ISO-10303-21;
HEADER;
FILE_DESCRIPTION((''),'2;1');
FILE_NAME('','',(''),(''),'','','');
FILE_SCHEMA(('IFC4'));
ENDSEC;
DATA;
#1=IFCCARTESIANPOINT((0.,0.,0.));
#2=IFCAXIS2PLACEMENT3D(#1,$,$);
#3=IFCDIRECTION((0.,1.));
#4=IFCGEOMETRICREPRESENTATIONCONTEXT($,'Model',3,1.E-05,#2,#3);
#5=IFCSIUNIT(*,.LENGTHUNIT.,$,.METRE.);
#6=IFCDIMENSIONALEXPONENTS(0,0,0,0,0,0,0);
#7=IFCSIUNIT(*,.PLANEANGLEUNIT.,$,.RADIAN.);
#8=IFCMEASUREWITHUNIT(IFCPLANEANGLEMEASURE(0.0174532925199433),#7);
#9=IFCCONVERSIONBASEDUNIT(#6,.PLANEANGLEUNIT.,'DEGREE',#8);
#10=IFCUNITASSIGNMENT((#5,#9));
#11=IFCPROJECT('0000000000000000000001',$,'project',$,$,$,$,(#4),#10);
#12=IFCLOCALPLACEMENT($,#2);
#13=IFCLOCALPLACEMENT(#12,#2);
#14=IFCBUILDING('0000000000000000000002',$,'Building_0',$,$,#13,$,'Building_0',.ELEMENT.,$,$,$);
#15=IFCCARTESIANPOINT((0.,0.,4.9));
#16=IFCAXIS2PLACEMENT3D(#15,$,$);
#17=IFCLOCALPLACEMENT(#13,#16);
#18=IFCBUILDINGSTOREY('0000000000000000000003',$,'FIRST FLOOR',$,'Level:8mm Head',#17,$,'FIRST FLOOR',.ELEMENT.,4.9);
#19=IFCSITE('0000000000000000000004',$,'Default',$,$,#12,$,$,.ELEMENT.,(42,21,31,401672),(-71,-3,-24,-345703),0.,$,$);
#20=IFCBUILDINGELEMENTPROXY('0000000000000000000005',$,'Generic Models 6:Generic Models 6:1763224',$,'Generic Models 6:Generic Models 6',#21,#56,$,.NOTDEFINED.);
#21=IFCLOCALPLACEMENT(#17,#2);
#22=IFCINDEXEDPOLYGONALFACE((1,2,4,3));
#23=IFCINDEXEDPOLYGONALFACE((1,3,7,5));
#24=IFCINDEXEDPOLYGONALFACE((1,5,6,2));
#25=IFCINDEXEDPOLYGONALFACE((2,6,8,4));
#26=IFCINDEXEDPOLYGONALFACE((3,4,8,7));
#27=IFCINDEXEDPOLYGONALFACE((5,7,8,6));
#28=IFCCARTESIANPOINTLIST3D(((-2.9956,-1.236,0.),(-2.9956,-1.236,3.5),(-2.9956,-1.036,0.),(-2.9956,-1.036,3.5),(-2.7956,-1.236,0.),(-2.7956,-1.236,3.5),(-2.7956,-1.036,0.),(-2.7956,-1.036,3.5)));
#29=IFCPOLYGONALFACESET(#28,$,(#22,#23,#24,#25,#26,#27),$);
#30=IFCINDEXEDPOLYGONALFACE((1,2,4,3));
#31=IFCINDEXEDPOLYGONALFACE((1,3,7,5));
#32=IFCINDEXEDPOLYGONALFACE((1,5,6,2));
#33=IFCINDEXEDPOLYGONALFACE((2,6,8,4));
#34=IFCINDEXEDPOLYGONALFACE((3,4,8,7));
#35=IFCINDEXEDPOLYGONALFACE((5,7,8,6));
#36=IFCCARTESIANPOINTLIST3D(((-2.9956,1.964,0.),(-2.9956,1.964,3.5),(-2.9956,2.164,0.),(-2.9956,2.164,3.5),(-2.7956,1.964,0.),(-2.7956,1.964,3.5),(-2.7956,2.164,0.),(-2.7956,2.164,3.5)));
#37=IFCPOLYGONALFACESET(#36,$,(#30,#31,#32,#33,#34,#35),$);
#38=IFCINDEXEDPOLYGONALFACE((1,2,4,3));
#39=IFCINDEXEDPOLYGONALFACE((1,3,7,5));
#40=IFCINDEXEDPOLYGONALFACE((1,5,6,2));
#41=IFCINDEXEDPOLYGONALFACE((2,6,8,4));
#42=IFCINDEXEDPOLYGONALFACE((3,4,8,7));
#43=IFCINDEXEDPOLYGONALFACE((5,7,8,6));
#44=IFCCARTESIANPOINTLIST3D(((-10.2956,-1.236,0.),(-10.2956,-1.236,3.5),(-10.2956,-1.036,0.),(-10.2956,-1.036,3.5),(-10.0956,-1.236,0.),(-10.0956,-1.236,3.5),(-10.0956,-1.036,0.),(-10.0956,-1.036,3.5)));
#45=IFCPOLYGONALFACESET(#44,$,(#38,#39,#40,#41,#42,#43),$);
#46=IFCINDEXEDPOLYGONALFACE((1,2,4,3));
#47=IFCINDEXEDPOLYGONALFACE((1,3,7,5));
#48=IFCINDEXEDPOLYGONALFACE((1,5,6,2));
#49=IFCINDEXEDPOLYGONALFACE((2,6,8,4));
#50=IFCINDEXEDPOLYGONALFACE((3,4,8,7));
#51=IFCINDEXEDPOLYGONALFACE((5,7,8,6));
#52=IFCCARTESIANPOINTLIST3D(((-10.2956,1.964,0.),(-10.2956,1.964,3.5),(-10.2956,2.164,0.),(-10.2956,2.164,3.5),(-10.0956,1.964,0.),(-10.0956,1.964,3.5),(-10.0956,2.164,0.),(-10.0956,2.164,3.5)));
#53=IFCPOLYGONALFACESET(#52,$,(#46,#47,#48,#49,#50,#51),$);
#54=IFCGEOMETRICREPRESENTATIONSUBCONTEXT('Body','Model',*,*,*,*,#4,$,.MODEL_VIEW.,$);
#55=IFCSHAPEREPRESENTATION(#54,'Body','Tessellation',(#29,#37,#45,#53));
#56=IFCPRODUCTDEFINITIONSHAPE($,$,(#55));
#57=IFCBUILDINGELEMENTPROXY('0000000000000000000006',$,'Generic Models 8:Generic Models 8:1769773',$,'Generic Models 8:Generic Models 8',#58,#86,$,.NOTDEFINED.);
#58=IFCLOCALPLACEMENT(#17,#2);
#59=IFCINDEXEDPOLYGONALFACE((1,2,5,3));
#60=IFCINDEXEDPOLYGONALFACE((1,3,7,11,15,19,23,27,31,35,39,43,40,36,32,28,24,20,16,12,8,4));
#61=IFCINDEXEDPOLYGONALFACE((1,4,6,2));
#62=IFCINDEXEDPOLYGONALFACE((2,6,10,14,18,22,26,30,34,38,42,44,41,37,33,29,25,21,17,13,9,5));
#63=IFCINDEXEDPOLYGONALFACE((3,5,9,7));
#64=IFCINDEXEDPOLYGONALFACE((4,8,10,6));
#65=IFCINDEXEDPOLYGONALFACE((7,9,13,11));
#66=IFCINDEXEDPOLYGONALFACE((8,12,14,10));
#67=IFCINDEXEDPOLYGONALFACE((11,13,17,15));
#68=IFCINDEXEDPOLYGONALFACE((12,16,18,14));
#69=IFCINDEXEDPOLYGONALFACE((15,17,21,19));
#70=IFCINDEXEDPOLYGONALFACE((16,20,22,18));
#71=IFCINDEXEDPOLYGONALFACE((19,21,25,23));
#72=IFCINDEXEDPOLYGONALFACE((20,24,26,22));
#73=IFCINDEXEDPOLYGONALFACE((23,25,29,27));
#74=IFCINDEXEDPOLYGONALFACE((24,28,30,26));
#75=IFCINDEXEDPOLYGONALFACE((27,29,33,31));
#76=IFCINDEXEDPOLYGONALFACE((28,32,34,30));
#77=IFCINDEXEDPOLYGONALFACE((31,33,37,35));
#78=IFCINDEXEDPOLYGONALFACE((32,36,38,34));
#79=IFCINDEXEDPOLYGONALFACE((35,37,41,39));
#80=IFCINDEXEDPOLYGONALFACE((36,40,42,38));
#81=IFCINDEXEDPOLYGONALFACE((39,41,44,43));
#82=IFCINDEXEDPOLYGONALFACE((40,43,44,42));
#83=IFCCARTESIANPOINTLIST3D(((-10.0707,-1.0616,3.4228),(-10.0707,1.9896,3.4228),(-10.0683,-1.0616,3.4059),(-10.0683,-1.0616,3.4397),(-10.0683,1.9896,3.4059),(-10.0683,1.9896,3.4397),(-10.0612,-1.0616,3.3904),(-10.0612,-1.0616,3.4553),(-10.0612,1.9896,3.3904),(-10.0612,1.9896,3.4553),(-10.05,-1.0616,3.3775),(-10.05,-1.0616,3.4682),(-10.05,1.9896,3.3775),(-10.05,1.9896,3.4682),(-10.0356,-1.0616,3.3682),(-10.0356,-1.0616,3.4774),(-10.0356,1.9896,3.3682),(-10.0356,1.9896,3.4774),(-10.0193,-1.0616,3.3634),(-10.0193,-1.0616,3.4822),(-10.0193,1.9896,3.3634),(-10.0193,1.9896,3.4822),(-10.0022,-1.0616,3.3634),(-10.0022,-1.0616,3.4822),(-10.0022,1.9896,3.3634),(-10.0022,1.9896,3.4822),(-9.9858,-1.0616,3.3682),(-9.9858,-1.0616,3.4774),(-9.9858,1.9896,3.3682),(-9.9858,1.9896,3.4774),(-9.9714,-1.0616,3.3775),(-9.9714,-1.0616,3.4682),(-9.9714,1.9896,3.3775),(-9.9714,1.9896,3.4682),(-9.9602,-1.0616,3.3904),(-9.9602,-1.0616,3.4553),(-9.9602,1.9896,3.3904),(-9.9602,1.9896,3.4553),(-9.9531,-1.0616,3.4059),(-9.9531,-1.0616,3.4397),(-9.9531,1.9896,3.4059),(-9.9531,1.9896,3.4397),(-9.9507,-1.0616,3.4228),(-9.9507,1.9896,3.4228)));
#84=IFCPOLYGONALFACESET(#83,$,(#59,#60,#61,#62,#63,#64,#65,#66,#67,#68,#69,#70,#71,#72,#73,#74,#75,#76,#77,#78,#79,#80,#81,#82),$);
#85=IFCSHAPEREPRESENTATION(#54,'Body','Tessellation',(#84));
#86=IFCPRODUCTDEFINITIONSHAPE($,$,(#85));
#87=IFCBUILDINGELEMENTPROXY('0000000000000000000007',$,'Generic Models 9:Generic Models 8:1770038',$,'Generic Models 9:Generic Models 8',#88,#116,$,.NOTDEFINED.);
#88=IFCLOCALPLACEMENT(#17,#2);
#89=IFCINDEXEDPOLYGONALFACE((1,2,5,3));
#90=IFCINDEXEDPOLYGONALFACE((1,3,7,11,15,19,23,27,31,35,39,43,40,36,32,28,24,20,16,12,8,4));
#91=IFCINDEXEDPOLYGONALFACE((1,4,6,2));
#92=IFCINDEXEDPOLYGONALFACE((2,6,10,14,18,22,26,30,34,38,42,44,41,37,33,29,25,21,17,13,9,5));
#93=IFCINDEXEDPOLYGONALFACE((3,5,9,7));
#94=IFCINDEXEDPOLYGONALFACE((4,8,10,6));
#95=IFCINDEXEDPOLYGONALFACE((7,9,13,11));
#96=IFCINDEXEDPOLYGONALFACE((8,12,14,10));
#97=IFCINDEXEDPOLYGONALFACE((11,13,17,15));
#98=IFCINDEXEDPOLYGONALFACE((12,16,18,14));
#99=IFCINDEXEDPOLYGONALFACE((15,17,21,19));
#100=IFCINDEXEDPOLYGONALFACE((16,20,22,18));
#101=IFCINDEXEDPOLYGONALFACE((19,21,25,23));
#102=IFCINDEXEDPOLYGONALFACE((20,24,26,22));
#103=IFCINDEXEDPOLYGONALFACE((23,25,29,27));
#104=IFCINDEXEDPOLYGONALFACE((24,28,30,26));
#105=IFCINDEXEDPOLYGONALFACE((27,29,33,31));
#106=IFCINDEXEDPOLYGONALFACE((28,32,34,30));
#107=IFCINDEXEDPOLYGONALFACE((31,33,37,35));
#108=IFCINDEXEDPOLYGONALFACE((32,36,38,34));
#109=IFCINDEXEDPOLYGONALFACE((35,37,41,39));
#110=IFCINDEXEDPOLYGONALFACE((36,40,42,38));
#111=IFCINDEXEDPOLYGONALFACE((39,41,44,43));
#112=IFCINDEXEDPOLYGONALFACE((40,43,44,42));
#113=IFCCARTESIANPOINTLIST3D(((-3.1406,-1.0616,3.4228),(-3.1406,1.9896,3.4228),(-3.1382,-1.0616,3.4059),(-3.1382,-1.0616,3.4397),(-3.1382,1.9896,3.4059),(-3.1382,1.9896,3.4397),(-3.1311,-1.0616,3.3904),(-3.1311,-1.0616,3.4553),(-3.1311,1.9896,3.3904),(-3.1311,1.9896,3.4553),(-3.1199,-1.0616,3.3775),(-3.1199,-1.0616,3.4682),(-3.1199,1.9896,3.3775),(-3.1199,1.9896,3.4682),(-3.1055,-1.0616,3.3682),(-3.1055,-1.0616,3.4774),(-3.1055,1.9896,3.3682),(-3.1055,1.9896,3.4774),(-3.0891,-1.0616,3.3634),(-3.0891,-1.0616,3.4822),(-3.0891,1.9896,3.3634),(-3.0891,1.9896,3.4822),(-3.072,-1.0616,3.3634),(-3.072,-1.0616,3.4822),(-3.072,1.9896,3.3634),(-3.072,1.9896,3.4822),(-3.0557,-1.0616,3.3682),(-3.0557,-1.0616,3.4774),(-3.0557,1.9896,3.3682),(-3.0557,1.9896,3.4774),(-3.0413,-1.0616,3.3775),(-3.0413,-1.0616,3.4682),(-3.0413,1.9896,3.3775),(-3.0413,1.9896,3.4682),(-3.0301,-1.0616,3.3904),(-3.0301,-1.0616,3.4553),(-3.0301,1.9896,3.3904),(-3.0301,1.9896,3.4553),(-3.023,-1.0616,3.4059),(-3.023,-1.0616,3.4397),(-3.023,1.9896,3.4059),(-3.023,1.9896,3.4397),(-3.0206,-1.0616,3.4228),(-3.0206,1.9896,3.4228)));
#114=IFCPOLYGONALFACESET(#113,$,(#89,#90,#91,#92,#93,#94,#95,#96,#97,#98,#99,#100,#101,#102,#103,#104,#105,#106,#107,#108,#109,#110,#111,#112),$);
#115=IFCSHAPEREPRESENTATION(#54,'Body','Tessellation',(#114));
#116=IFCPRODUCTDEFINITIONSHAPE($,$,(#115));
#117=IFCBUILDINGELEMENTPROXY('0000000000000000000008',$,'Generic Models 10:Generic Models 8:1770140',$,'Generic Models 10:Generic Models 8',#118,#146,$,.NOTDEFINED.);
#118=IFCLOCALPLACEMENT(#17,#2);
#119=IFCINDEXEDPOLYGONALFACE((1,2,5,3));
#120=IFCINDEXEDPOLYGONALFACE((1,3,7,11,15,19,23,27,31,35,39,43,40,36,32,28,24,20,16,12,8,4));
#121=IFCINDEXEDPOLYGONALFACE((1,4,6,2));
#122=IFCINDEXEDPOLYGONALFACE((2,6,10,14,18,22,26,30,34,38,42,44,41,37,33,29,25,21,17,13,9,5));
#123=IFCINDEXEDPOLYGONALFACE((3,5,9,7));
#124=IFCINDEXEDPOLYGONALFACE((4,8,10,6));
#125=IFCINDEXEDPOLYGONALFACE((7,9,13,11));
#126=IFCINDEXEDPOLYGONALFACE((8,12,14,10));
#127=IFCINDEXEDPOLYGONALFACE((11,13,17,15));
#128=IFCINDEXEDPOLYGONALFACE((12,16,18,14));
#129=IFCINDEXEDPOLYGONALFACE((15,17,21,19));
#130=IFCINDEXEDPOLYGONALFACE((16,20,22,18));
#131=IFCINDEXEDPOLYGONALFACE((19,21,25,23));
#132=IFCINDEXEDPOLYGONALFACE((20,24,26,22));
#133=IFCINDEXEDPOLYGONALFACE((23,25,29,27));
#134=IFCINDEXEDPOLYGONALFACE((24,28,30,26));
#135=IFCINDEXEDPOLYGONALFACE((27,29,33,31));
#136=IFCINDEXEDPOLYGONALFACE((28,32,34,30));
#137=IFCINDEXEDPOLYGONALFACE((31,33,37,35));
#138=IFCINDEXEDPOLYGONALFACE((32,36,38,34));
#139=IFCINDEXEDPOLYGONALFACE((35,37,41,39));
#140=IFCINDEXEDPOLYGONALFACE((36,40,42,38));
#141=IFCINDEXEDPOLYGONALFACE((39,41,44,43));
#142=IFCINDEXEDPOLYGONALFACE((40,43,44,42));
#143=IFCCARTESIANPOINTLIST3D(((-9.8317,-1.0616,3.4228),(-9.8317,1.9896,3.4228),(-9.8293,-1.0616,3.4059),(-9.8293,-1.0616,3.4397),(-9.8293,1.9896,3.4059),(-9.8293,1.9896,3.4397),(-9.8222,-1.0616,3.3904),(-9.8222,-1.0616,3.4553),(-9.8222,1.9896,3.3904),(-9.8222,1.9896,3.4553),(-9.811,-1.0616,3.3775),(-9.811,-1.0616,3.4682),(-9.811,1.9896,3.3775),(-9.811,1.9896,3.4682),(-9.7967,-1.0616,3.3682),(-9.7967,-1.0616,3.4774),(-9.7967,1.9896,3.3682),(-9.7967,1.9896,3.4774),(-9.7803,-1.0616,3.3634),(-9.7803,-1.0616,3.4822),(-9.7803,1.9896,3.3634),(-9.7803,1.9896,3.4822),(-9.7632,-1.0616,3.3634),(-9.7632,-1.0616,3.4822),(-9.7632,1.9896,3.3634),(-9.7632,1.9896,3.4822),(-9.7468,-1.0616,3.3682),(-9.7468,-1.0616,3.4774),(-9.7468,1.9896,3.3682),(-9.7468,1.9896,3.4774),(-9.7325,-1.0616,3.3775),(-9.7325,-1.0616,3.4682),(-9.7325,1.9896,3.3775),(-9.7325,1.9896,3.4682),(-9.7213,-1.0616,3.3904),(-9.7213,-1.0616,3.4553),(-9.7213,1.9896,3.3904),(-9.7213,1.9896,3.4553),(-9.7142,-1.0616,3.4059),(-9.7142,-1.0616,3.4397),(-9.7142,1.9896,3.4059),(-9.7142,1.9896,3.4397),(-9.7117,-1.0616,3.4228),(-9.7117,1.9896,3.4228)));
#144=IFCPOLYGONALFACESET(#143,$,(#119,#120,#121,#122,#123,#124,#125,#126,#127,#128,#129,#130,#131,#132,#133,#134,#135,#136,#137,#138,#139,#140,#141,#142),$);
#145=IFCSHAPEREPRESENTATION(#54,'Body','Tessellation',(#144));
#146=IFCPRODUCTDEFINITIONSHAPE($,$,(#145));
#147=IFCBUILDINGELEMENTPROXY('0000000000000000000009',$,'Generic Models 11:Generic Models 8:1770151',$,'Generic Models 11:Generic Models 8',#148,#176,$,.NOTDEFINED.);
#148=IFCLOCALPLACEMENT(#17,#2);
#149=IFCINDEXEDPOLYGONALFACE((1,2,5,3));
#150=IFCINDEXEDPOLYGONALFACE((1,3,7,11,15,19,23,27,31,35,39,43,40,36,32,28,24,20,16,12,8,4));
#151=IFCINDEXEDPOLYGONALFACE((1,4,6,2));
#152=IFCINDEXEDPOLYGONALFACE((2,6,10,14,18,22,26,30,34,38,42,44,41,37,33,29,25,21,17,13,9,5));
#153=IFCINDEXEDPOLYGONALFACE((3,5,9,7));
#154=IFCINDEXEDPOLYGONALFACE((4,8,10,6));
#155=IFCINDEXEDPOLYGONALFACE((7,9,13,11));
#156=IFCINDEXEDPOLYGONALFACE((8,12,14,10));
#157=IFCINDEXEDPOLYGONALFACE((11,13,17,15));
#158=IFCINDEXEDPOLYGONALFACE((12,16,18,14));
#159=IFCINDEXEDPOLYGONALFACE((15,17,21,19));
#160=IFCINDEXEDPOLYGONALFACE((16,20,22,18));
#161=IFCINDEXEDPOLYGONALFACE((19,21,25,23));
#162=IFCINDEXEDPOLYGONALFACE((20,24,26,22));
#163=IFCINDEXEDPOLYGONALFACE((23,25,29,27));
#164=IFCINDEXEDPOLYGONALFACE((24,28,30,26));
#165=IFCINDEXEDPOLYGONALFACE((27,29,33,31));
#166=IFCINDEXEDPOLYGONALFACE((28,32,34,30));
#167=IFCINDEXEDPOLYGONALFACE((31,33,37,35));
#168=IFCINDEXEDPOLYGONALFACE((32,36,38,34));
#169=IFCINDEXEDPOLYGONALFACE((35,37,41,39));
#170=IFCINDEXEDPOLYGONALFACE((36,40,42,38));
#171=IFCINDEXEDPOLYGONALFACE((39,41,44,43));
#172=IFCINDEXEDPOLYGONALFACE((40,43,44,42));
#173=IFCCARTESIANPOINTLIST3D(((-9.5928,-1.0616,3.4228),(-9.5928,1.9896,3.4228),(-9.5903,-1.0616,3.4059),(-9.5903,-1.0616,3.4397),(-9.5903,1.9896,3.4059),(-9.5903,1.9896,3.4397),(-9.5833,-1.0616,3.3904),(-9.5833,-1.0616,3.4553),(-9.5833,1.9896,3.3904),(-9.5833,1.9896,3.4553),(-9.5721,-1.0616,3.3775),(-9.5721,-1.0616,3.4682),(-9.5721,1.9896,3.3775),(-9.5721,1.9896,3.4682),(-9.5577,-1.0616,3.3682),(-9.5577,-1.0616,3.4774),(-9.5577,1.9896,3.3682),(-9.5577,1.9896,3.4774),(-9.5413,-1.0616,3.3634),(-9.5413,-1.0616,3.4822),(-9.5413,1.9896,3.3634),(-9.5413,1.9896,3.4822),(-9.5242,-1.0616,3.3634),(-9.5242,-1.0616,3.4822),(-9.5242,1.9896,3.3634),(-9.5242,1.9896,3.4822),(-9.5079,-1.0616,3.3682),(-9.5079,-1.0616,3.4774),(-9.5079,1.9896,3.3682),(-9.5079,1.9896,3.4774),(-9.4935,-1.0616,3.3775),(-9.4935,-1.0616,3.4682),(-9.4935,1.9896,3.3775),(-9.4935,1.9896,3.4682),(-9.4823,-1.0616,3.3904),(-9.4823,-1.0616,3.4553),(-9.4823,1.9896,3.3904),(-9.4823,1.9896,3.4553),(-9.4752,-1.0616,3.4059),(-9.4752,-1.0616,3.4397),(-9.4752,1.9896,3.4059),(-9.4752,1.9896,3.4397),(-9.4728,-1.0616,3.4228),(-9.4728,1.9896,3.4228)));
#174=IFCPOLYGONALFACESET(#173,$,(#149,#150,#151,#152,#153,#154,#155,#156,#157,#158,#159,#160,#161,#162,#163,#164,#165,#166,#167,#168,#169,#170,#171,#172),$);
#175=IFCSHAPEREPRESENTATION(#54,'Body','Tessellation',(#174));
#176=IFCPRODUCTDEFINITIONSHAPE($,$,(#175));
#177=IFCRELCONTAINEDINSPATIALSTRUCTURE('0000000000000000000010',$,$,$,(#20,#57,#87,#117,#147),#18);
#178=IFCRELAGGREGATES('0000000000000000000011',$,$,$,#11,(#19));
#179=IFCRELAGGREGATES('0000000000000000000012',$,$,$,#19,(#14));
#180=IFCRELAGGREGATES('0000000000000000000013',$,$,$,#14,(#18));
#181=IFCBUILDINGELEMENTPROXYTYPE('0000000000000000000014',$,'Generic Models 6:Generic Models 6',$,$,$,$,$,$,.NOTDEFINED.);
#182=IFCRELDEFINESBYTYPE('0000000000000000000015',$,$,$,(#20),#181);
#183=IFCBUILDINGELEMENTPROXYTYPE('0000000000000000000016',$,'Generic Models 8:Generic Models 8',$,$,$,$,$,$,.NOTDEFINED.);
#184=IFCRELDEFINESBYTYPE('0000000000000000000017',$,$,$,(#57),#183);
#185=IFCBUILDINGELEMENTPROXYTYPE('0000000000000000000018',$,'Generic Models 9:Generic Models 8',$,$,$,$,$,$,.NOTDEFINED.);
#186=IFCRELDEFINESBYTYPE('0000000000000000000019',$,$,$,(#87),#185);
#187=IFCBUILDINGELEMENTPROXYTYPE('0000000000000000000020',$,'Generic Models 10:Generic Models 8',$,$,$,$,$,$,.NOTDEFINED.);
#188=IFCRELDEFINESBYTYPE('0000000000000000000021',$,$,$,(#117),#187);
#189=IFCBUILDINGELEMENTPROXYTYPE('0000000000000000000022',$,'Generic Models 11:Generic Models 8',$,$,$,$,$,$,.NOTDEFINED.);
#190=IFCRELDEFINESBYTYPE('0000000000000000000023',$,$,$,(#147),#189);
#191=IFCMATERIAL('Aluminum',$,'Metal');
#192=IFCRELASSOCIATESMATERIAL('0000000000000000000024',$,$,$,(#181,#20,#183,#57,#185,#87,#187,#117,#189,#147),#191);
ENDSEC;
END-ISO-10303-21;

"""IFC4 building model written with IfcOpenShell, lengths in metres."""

from ifc_helpers import new_model, entity, si_unit, converted_unit, direction, frame, origin, place, context, subcontext, project, spatial, arc, indexed_curve, outline, extrude, source, transform, mapped, material, type_object, type_shapes, element, save


model = new_model("IFC4")

# Units and contexts
model_context = context("Model", 3, precision=1e-05, world=origin(), true_north=direction((0.0, 1.0)))
body_context = subcontext(model_context, "Body", "Model", "MODEL_VIEW")
ifc_project = project(units=[si_unit("LENGTHUNIT", "METRE"), converted_unit("PLANEANGLEUNIT", "DEGREE", entity("IfcPlaneAngleMeasure", 0.0174532925199433), si_unit("PLANEANGLEUNIT", "RADIAN"), dimensions=[0, 0, 0, 0, 0, 0, 0])], contexts=[model_context])

# Site, building, storey
site_placement = place(None, origin())
site = spatial("IfcSite", under=ifc_project, at=site_placement, Name="Default", CompositionType="ELEMENT", RefLatitude=(42, 21, 31, 401672), RefLongitude=(-71, -3, -24, -345703), RefElevation=0.0)
building_placement = place(site_placement, origin())
building = spatial("IfcBuilding", under=site, at=building_placement, Name="Building_0", LongName="Building_0", CompositionType="ELEMENT")
storey_placement = place(building_placement, frame((0.0, 0.0, 4.9)))
storey = spatial("IfcBuildingStorey", under=building, at=storey_placement, Name="FIRST FLOOR", ObjectType="Level:8mm Head", LongName="FIRST FLOOR", CompositionType="ELEMENT", Elevation=4.9)

# Shared definitions
ifc_material_1 = material(Name="Aluminum", Category="Metal")

# Building element proxies
building_element_proxy_type_1 = type_object("IfcBuildingElementProxyType", Name="Generic Models 6:Generic Models 6", PredefinedType="NOTDEFINED", material=ifc_material_1)
shared_shape_1 = source(origin(), body_context, "Body", "SweptSolid", [
    extrude(outline(indexed_curve([(-0.1, -0.1), (0.1, -0.1), (0.1, 0.1), (-0.1, 0.1), (-0.1, -0.1)], self_intersect=False)), frame((-2.8956, -1.136, 4.9), z_axis=(0.0, 0.0, 1.0), x_axis=(0.0, 1.0, 0.0)), (0.0, 0.0, 1.0), 3.5),
    extrude(outline(indexed_curve([(-0.1, -0.1), (0.1, -0.1), (0.1, 0.1), (-0.1, 0.1), (-0.1, -0.1)], self_intersect=False)), frame((-2.8956, 2.064, 4.9), z_axis=(0.0, 0.0, 1.0), x_axis=(0.0, 1.0, 0.0)), (0.0, 0.0, 1.0), 3.5),
    extrude(outline(indexed_curve([(-0.1, -0.1), (0.1, -0.1), (0.1, 0.1), (-0.1, 0.1), (-0.1, -0.1)], self_intersect=False)), frame((-10.1956, -1.136, 4.9), z_axis=(0.0, 0.0, 1.0), x_axis=(0.0, 1.0, 0.0)), (0.0, 0.0, 1.0), 3.5),
    extrude(outline(indexed_curve([(-0.1, -0.1), (0.1, -0.1), (0.1, 0.1), (-0.1, 0.1), (-0.1, -0.1)], self_intersect=False)), frame((-10.1956, 2.064, 4.9), z_axis=(0.0, 0.0, 1.0), x_axis=(0.0, 1.0, 0.0)), (0.0, 0.0, 1.0), 3.5),
])
type_shapes(building_element_proxy_type_1, [shared_shape_1])
proxy_1_placement = place(storey_placement, frame((0.0, 0.0, -4.9)))
element("IfcBuildingElementProxy", 1, at=proxy_1_placement, inside=storey, type_object=building_element_proxy_type_1, material=ifc_material_1, Name="Generic Models 6:Generic Models 6:1763224", ObjectType="Generic Models 6:Generic Models 6", PredefinedType="NOTDEFINED", context=body_context, shape_type="MappedRepresentation", body=[
    mapped(shared_shape_1, transform((0.0, 0.0, 0.0), scale=1.0)),
])
building_element_proxy_type_2 = type_object("IfcBuildingElementProxyType", Name="Generic Models 8:Generic Models 8", PredefinedType="NOTDEFINED", material=ifc_material_1)
shared_shape_2 = source(origin(), body_context, "Body", "SweptSolid", [
    extrude(outline(indexed_curve([(-0.06, 0.0), (0.0, -0.06), (0.06, 0.0), (0.0, 0.06)], segments=[arc(1, 2, 3), arc(3, 4, 1)], self_intersect=False)), frame((-10.0107, -1.0616, 8.3228), z_axis=(0.0, 1.0, 0.0), x_axis=(-1.0, 0.0, 0.0)), (0.0, 0.0, 1.0), 3.0512),
])
type_shapes(building_element_proxy_type_2, [shared_shape_2])
proxy_2_placement = place(storey_placement, frame((0.0, 0.0, -4.9)))
element("IfcBuildingElementProxy", 2, at=proxy_2_placement, inside=storey, type_object=building_element_proxy_type_2, material=ifc_material_1, Name="Generic Models 8:Generic Models 8:1769773", ObjectType="Generic Models 8:Generic Models 8", PredefinedType="NOTDEFINED", context=body_context, shape_type="MappedRepresentation", body=[
    mapped(shared_shape_2, transform((0.0, 0.0, 0.0), scale=1.0)),
])
building_element_proxy_type_3 = type_object("IfcBuildingElementProxyType", Name="Generic Models 9:Generic Models 8", PredefinedType="NOTDEFINED", material=ifc_material_1)
shared_shape_3 = source(origin(), body_context, "Body", "SweptSolid", [
    extrude(outline(indexed_curve([(-0.06, 0.0), (0.0, -0.06), (0.06, 0.0), (0.0, 0.06)], segments=[arc(1, 2, 3), arc(3, 4, 1)], self_intersect=False)), frame((-3.0806, -1.0616, 8.3228), z_axis=(0.0, 1.0, 0.0), x_axis=(-1.0, 0.0, 0.0)), (0.0, 0.0, 1.0), 3.0512),
])
type_shapes(building_element_proxy_type_3, [shared_shape_3])
proxy_3_placement = place(storey_placement, frame((0.0, 0.0, -4.9)))
element("IfcBuildingElementProxy", 3, at=proxy_3_placement, inside=storey, type_object=building_element_proxy_type_3, material=ifc_material_1, Name="Generic Models 9:Generic Models 8:1770038", ObjectType="Generic Models 9:Generic Models 8", PredefinedType="NOTDEFINED", context=body_context, shape_type="MappedRepresentation", body=[
    mapped(shared_shape_3, transform((0.0, 0.0, 0.0), scale=1.0)),
])
building_element_proxy_type_4 = type_object("IfcBuildingElementProxyType", Name="Generic Models 10:Generic Models 8", PredefinedType="NOTDEFINED", material=ifc_material_1)
shared_shape_4 = source(origin(), body_context, "Body", "SweptSolid", [
    extrude(outline(indexed_curve([(-0.06, 0.0), (0.0, -0.06), (0.06, 0.0), (0.0, 0.06)], segments=[arc(1, 2, 3), arc(3, 4, 1)], self_intersect=False)), frame((-9.7717, -1.0616, 8.3228), z_axis=(0.0, 1.0, 0.0), x_axis=(-1.0, 0.0, 0.0)), (0.0, 0.0, 1.0), 3.0512),
])
type_shapes(building_element_proxy_type_4, [shared_shape_4])
proxy_4_placement = place(storey_placement, frame((0.0, 0.0, -4.9)))
element("IfcBuildingElementProxy", 4, at=proxy_4_placement, inside=storey, type_object=building_element_proxy_type_4, material=ifc_material_1, Name="Generic Models 10:Generic Models 8:1770140", ObjectType="Generic Models 10:Generic Models 8", PredefinedType="NOTDEFINED", context=body_context, shape_type="MappedRepresentation", body=[
    mapped(shared_shape_4, transform((0.0, 0.0, 0.0), scale=1.0)),
])
building_element_proxy_type_5 = type_object("IfcBuildingElementProxyType", Name="Generic Models 11:Generic Models 8", PredefinedType="NOTDEFINED", material=ifc_material_1)
shared_shape_5 = source(origin(), body_context, "Body", "SweptSolid", [
    extrude(outline(indexed_curve([(-0.06, 0.0), (0.0, -0.06), (0.06, 0.0), (0.0, 0.06)], segments=[arc(1, 2, 3), arc(3, 4, 1)], self_intersect=False)), frame((-9.5328, -1.0616, 8.3228), z_axis=(0.0, 1.0, 0.0), x_axis=(-1.0, 0.0, 0.0)), (0.0, 0.0, 1.0), 3.0512),
])
type_shapes(building_element_proxy_type_5, [shared_shape_5])
proxy_5_placement = place(storey_placement, frame((0.0, 0.0, -4.9)))
element("IfcBuildingElementProxy", 5, at=proxy_5_placement, inside=storey, type_object=building_element_proxy_type_5, material=ifc_material_1, Name="Generic Models 11:Generic Models 8:1770151", ObjectType="Generic Models 11:Generic Models 8", PredefinedType="NOTDEFINED", context=body_context, shape_type="MappedRepresentation", body=[
    mapped(shared_shape_5, transform((0.0, 0.0, 0.0), scale=1.0)),
])

save(model, "model.ifc")
